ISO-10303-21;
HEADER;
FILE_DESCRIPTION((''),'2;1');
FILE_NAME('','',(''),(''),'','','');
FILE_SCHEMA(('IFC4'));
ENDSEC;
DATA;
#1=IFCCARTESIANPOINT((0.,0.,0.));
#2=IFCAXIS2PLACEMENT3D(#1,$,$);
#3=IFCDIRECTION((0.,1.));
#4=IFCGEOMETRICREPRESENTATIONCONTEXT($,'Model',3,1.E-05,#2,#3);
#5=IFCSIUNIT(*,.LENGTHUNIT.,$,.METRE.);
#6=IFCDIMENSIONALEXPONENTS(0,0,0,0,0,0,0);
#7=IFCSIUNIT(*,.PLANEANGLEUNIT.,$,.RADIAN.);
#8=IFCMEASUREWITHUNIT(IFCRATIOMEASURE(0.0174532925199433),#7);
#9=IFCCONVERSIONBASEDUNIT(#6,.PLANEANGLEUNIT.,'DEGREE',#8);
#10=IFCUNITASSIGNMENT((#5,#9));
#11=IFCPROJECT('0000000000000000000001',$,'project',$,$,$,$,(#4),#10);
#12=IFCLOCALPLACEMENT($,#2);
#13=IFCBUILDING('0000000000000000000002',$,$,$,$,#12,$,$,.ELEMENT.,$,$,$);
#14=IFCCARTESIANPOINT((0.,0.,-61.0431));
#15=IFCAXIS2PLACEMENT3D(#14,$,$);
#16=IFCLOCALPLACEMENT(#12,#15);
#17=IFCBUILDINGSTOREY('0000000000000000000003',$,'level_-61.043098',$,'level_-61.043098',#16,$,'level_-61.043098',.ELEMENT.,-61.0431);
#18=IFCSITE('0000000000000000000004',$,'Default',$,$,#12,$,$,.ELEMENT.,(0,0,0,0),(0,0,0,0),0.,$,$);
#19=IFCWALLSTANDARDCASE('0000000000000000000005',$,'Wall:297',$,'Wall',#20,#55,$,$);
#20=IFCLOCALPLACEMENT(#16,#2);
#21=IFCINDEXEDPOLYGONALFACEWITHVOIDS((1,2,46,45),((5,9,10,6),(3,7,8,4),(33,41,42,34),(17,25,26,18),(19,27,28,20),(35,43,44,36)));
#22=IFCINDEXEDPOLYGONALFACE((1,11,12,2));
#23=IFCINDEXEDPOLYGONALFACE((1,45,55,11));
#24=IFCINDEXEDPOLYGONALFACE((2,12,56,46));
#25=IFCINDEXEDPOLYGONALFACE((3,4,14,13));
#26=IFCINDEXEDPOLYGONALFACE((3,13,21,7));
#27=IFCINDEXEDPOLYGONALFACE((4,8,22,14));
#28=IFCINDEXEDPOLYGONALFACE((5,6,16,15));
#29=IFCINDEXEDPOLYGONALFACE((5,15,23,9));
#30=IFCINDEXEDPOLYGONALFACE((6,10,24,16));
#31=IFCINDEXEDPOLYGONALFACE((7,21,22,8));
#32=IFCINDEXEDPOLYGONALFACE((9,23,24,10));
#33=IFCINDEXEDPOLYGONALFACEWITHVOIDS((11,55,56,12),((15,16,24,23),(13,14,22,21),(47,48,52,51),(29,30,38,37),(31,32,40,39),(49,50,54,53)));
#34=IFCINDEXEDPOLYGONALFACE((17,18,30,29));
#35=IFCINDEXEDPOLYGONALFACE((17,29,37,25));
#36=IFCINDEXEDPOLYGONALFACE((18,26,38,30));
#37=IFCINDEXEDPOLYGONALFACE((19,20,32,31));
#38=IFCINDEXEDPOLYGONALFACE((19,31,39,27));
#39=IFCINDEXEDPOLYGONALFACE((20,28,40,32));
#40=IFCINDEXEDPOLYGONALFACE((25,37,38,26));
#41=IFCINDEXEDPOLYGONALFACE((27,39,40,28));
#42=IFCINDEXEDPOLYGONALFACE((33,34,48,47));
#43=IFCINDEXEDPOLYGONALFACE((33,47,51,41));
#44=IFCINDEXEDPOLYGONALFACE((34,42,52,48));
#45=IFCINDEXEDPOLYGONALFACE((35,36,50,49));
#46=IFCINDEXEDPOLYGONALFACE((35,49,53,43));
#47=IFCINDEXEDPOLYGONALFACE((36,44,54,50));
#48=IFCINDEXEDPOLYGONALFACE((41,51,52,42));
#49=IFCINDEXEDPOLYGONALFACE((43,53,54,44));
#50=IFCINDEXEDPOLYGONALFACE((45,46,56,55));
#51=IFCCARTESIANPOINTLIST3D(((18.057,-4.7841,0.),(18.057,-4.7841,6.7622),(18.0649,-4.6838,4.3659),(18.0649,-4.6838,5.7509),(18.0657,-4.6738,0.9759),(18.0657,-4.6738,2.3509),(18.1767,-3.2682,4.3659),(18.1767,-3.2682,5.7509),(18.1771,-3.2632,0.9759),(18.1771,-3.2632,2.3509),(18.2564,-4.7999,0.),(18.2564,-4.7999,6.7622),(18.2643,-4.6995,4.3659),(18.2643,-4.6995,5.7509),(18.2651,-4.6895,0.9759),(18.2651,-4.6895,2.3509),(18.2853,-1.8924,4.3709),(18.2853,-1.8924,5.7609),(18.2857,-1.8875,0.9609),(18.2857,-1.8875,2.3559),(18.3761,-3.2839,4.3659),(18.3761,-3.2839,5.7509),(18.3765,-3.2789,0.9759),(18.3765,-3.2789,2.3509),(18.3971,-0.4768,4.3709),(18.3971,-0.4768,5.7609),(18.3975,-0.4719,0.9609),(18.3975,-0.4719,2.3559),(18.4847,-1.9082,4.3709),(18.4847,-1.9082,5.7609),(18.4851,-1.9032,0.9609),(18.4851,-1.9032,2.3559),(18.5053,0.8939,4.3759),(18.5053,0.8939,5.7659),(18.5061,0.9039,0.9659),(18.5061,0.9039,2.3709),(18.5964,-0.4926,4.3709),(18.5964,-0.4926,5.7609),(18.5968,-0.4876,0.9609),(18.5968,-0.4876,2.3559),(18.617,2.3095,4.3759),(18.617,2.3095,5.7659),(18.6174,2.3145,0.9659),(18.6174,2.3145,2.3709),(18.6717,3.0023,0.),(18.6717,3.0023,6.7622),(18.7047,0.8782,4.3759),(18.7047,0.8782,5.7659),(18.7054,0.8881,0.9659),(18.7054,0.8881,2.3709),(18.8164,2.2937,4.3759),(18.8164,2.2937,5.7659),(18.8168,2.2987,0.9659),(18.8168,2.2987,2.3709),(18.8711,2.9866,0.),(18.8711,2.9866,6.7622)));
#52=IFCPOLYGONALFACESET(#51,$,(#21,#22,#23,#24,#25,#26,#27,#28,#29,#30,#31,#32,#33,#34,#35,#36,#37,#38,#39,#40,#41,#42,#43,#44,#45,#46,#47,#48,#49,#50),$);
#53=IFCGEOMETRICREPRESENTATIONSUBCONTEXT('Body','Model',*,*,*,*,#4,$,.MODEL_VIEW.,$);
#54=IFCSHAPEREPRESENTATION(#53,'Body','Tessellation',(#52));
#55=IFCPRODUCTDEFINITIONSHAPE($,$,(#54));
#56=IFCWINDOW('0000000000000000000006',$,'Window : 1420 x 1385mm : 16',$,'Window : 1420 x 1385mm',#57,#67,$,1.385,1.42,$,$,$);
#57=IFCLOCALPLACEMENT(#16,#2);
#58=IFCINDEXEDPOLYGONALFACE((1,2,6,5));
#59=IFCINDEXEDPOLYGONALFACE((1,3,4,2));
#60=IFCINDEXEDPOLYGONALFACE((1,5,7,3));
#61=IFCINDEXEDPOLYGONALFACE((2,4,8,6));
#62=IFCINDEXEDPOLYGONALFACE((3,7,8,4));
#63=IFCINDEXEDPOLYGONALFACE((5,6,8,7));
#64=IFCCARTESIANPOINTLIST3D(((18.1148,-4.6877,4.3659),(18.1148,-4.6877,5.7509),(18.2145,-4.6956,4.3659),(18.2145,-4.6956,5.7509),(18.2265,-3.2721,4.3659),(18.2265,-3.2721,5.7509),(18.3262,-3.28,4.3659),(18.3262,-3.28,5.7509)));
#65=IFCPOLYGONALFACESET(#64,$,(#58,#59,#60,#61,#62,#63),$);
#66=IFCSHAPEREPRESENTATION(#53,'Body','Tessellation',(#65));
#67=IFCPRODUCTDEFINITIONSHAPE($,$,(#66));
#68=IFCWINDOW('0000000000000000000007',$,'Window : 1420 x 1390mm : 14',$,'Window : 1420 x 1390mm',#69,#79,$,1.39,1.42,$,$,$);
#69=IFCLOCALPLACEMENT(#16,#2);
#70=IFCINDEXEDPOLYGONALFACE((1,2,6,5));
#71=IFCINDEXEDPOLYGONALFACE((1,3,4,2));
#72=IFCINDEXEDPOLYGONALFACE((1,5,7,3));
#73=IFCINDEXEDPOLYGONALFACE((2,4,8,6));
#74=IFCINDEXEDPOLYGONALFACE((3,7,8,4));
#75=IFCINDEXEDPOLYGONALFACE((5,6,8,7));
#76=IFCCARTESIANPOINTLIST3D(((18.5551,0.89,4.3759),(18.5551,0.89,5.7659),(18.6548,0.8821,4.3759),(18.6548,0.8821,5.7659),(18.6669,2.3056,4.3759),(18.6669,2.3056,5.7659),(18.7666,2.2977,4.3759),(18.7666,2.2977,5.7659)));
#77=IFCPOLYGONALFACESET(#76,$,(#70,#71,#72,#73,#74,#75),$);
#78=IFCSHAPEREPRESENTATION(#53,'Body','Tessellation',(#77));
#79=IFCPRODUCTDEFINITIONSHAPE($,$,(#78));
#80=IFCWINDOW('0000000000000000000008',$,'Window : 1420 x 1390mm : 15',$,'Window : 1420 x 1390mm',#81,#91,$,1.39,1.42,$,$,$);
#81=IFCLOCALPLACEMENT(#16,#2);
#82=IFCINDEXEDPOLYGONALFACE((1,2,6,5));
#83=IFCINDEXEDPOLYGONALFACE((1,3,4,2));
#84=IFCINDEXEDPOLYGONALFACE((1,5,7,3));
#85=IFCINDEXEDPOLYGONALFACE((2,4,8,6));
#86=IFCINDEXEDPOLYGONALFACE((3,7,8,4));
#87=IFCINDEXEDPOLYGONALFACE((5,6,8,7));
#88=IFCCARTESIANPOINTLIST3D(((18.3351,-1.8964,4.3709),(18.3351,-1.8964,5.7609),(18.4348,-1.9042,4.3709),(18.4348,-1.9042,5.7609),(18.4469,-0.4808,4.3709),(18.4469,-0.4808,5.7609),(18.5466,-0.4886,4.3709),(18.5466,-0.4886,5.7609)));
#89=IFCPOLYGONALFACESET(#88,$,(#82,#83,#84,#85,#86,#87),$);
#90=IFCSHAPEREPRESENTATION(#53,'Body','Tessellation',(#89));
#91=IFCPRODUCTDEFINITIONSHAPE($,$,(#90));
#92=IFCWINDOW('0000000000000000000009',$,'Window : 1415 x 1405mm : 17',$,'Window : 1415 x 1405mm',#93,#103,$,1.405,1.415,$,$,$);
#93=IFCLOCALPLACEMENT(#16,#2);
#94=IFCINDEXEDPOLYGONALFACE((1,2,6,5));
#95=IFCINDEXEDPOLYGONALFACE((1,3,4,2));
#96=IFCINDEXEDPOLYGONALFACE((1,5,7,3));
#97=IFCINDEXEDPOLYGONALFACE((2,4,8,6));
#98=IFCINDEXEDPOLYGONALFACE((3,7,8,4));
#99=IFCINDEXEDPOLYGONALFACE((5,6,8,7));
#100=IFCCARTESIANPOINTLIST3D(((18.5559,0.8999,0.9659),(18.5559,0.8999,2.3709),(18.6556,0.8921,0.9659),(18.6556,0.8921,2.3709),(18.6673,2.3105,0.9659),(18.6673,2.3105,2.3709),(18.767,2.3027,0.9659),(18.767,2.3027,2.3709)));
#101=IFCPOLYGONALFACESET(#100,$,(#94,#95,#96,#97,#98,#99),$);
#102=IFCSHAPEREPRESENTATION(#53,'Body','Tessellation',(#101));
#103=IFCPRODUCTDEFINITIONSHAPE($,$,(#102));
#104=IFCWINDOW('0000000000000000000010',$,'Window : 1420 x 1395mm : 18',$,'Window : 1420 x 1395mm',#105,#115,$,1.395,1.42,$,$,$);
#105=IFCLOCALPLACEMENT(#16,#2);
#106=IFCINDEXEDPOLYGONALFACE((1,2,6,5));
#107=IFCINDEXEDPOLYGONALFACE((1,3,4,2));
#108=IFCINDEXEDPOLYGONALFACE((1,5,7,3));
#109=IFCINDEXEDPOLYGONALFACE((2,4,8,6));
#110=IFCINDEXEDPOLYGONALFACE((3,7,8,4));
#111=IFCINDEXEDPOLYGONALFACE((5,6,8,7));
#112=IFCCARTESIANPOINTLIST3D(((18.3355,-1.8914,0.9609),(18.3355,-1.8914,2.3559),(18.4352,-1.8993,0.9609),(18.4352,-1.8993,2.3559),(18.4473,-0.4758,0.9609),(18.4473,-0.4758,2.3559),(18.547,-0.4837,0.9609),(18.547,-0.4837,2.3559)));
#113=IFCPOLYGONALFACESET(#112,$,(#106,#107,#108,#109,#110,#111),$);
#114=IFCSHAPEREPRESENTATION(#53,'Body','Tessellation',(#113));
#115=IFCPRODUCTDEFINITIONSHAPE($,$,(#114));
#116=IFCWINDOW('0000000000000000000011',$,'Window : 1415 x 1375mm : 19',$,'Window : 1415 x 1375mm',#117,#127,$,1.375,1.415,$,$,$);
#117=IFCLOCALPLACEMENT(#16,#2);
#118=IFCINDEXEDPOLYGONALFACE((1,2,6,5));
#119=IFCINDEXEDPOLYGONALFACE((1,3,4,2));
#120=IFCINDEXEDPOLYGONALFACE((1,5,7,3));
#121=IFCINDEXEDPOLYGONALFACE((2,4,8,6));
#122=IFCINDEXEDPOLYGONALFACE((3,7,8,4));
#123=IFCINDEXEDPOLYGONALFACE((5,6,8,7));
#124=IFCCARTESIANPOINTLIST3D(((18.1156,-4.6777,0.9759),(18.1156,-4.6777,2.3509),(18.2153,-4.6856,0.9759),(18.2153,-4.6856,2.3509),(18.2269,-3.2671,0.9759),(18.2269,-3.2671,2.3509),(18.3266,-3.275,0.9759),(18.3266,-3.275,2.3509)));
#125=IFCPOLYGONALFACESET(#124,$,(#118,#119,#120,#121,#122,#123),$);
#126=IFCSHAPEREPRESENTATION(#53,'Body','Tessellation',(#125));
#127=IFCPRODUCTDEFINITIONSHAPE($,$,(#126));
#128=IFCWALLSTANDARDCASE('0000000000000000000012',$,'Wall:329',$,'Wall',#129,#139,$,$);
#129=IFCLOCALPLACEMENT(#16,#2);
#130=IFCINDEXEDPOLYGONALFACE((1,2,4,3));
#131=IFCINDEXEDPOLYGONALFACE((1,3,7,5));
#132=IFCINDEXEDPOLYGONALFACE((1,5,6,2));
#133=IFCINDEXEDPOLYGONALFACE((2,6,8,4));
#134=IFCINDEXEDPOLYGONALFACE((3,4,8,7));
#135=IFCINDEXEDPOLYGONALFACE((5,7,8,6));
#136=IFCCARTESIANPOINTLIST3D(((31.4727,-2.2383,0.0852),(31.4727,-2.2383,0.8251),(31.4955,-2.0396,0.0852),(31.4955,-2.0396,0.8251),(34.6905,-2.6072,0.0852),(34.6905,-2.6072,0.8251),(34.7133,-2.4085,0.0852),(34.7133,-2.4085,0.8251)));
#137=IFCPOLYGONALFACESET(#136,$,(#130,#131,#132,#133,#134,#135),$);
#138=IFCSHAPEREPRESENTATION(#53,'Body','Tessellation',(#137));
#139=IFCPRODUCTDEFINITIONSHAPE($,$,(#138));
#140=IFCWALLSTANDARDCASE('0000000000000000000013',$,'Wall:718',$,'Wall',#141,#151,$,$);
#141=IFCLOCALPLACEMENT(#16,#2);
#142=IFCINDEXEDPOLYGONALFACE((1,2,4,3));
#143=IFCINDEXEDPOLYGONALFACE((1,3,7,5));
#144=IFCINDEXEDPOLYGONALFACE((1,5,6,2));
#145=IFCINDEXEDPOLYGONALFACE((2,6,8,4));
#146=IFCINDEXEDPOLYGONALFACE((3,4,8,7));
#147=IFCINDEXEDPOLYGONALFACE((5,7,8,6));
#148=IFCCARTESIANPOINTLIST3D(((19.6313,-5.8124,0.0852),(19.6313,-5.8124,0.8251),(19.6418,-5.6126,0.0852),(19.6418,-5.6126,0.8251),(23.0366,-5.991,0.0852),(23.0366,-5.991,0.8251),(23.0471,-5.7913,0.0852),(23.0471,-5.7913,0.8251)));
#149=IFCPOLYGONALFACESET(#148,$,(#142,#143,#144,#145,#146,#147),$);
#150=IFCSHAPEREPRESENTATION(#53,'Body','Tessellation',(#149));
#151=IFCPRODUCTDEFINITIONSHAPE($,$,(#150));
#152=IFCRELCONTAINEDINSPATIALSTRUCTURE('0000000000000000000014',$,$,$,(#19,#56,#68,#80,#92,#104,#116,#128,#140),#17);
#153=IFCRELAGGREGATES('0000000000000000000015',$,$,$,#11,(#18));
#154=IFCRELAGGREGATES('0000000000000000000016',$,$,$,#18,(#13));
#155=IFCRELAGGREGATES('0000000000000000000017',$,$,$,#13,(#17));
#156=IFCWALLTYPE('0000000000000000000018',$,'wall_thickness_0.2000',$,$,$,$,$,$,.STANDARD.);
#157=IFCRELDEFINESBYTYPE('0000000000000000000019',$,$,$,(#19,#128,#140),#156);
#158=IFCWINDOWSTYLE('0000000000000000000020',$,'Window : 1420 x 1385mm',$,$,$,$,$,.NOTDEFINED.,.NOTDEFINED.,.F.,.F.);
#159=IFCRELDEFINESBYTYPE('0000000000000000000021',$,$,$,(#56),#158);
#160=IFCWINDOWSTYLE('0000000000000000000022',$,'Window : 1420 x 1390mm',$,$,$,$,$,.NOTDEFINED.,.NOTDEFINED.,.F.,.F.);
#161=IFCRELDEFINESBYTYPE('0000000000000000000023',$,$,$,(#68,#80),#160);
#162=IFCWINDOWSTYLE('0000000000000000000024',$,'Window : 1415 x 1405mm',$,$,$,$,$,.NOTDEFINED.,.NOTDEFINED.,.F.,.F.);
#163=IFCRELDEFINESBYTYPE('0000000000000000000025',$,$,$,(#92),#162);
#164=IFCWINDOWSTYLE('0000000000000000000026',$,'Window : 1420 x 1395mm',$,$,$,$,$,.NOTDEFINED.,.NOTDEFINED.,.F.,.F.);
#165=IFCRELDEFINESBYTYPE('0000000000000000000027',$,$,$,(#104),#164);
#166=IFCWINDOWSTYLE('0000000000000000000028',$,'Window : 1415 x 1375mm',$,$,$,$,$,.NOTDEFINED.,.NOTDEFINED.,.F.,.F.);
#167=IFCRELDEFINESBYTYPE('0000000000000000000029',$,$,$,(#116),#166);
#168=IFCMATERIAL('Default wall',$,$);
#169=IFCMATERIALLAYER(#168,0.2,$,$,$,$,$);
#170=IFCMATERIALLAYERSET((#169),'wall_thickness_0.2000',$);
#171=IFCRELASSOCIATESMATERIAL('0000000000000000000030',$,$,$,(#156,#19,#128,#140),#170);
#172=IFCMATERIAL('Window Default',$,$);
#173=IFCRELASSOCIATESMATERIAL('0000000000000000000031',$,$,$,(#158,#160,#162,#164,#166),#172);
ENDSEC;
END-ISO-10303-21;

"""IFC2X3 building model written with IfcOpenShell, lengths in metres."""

from ifc_helpers import new_model, entity, si_unit, converted_unit, direction, frame, frame_2d, origin, origin_2d_with_axis, place, context, subcontext, project, spatial, polyline, rectangle, outline, extrude, source, transform, mapped, material, layer, layer_set, layer_usage, type_object, type_shapes, element, fill, save


model = new_model("IFC2X3")

# Units and contexts
model_context = context("Model", 3, precision=1e-05, world=origin(), true_north=direction((0.0, 1.0)))
body_context = subcontext(model_context, "Body", "Model", "MODEL_VIEW")
ifc_project = project(units=[si_unit("LENGTHUNIT", "METRE"), converted_unit("PLANEANGLEUNIT", "DEGREE", entity("IfcRatioMeasure", 0.0174532925199433), si_unit("PLANEANGLEUNIT", "RADIAN"), dimensions=[0, 0, 0, 0, 0, 0, 0])], contexts=[model_context])

# Site, building, storey
placement_1 = place(None, origin())
site = spatial("IfcSite", under=ifc_project, at=placement_1, Name="Default", CompositionType="ELEMENT", RefLatitude=(0, 0, 0, 0), RefLongitude=(0, 0, 0, 0), RefElevation=0.0)
building = spatial("IfcBuilding", under=site, at=placement_1, CompositionType="ELEMENT")
storey_placement = place(placement_1, frame((0.0, 0.0, -61.0431)))
storey = spatial("IfcBuildingStorey", under=building, at=storey_placement, Name="level_-61.043098", ObjectType="level_-61.043098", LongName="level_-61.043098", CompositionType="ELEMENT", Elevation=-61.0431)

# Wall, openings, windows
ifc_material_1 = material(Name="Default wall")
ifc_layer = layer(ifc_material_1, 0.2)
ifc_layer_set = layer_set([ifc_layer], Name="wall_thickness_0.2000")
ifc_layer_usage = layer_usage(ifc_layer_set, "AXIS2", "POSITIVE", -0.1)
wall_type = type_object("IfcWallType", Name="wall_thickness_0.2000", PredefinedType="STANDARD", material=ifc_layer_set)
wall_1_placement = place(storey_placement, frame((18.7714, 2.9945, 0.0), z_axis=(0.0, 0.0, 1.0), x_axis=(-0.078701, -0.996898, 0.0)))
wall_1 = element("IfcWallStandardCase", 1, at=wall_1_placement, inside=storey, type_object=wall_type, material=ifc_layer_usage, Name="Wall:297", ObjectType="Wall", context=body_context, shape_type="SweptSolid", body=[
    extrude(outline(polyline([(7.8107, -0.1), (7.8107, 0.1), (0.0, 0.1), (0.0, -0.1), (7.8107, -0.1)])), origin(), (0.0, 0.0, 1.0), 6.7622),
])
opening_1_placement = place(wall_1_placement, frame((0.695, -0.1, 4.3759)))
opening_1 = element("IfcOpeningElement", 2, at=opening_1_placement, cuts=wall_1, ObjectType="Opening", context=body_context, shape_type="SweptSolid", body=[
    extrude(rectangle(XDim=1.42, YDim=1.39, at=frame_2d((0.695, 0.71), x_axis=(0.0, 1.0))), frame((0.0, 0.0, 0.0), z_axis=(0.0, 1.0, 0.0), x_axis=(0.0, 0.0, 1.0)), (0.0, 0.0, 1.0), 0.2),
])
opening_2_placement = place(wall_1_placement, frame((3.49, -0.1, 4.3709)))
opening_2 = element("IfcOpeningElement", 3, at=opening_2_placement, cuts=wall_1, ObjectType="Opening", context=body_context, shape_type="SweptSolid", body=[
    extrude(rectangle(XDim=1.42, YDim=1.39, at=frame_2d((0.695, 0.71), x_axis=(0.0, 1.0))), frame((0.0, 0.0, 0.0), z_axis=(0.0, 1.0, 0.0), x_axis=(0.0, 0.0, 1.0)), (0.0, 0.0, 1.0), 0.2),
])
opening_3_placement = place(wall_1_placement, frame((6.29, -0.1, 4.3659)))
opening_3 = element("IfcOpeningElement", 4, at=opening_3_placement, cuts=wall_1, ObjectType="Opening", context=body_context, shape_type="SweptSolid", body=[
    extrude(rectangle(XDim=1.42, YDim=1.385, at=frame_2d((0.6925, 0.71), x_axis=(0.0, 1.0))), frame((0.0, 0.0, 0.0), z_axis=(0.0, 1.0, 0.0), x_axis=(0.0, 0.0, 1.0)), (0.0, 0.0, 1.0), 0.2),
])
opening_4_placement = place(wall_1_placement, frame((0.69, -0.1, 0.9659)))
opening_4 = element("IfcOpeningElement", 5, at=opening_4_placement, cuts=wall_1, ObjectType="Opening", context=body_context, shape_type="SweptSolid", body=[
    extrude(rectangle(XDim=1.415, YDim=1.405, at=frame_2d((0.7025, 0.7075), x_axis=(0.0, 1.0))), frame((0.0, 0.0, 0.0), z_axis=(0.0, 1.0, 0.0), x_axis=(0.0, 0.0, 1.0)), (0.0, 0.0, 1.0), 0.2),
])
opening_5_placement = place(wall_1_placement, frame((3.485, -0.1, 0.9609)))
opening_5 = element("IfcOpeningElement", 6, at=opening_5_placement, cuts=wall_1, ObjectType="Opening", context=body_context, shape_type="SweptSolid", body=[
    extrude(rectangle(XDim=1.42, YDim=1.395, at=frame_2d((0.6975, 0.71), x_axis=(0.0, 1.0))), frame((0.0, 0.0, 0.0), z_axis=(0.0, 1.0, 0.0), x_axis=(0.0, 0.0, 1.0)), (0.0, 0.0, 1.0), 0.2),
])
opening_6_placement = place(wall_1_placement, frame((6.285, -0.1, 0.9759)))
opening_6 = element("IfcOpeningElement", 7, at=opening_6_placement, cuts=wall_1, ObjectType="Opening", context=body_context, shape_type="SweptSolid", body=[
    extrude(rectangle(XDim=1.415, YDim=1.375, at=frame_2d((0.6875, 0.7075), x_axis=(0.0, 1.0))), frame((0.0, 0.0, 0.0), z_axis=(0.0, 1.0, 0.0), x_axis=(0.0, 0.0, 1.0)), (0.0, 0.0, 1.0), 0.2),
])
ifc_material_2 = material(Name="Window Default")
window_style_1 = type_object("IfcWindowStyle", Name="Window : 1420 x 1385mm", ConstructionType="NOTDEFINED", OperationType="NOTDEFINED", ParameterTakesPrecedence=False, Sizeable=False, material=ifc_material_2)
shared_shape_1 = source(origin(), body_context, "Body", "SweptSolid", [
    extrude(rectangle(XDim=0.1, YDim=1.42, at=origin_2d_with_axis()), frame((0.71, 0.1, 0.0), z_axis=(0.0, 0.0, 1.0), x_axis=(0.0, 1.0, 0.0)), (0.0, 0.0, 1.0), 1.385),
])
type_shapes(window_style_1, [shared_shape_1])
window_1_placement = place(opening_3_placement, origin())
window_1 = element("IfcWindow", 8, at=window_1_placement, inside=storey, type_object=window_style_1, Name="Window : 1420 x 1385mm : 16", ObjectType="Window : 1420 x 1385mm", OverallHeight=1.385, OverallWidth=1.42, context=body_context, shape_type="MappedRepresentation", body=[
    mapped(shared_shape_1, transform((0.0, 0.0, 0.0), scale=1.0)),
])
fill(opening_3, window_1)
window_style_2 = type_object("IfcWindowStyle", Name="Window : 1420 x 1390mm", ConstructionType="NOTDEFINED", OperationType="NOTDEFINED", ParameterTakesPrecedence=False, Sizeable=False, material=ifc_material_2)
shared_shape_2 = source(origin(), body_context, "Body", "SweptSolid", [
    extrude(rectangle(XDim=0.1, YDim=1.42, at=origin_2d_with_axis()), frame((0.71, 0.1, 0.0), z_axis=(0.0, 0.0, 1.0), x_axis=(0.0, 1.0, 0.0)), (0.0, 0.0, 1.0), 1.39),
])
type_shapes(window_style_2, [shared_shape_2])
window_2_placement = place(opening_1_placement, origin())
window_2 = element("IfcWindow", 9, at=window_2_placement, inside=storey, type_object=window_style_2, Name="Window : 1420 x 1390mm : 14", ObjectType="Window : 1420 x 1390mm", OverallHeight=1.39, OverallWidth=1.42, context=body_context, shape_type="MappedRepresentation", body=[
    mapped(shared_shape_2, transform((0.0, 0.0, 0.0), scale=1.0)),
])
fill(opening_1, window_2)
window_3_placement = place(opening_2_placement, origin())
window_3 = element("IfcWindow", 10, at=window_3_placement, inside=storey, type_object=window_style_2, Name="Window : 1420 x 1390mm : 15", ObjectType="Window : 1420 x 1390mm", OverallHeight=1.39, OverallWidth=1.42, context=body_context, shape_type="MappedRepresentation", body=[
    mapped(shared_shape_2, transform((0.0, 0.0, 0.0), scale=1.0)),
])
fill(opening_2, window_3)
window_style_3 = type_object("IfcWindowStyle", Name="Window : 1415 x 1405mm", ConstructionType="NOTDEFINED", OperationType="NOTDEFINED", ParameterTakesPrecedence=False, Sizeable=False, material=ifc_material_2)
shared_shape_3 = source(origin(), body_context, "Body", "SweptSolid", [
    extrude(rectangle(XDim=0.1, YDim=1.415, at=origin_2d_with_axis()), frame((0.7075, 0.1, 0.0), z_axis=(0.0, 0.0, 1.0), x_axis=(0.0, 1.0, 0.0)), (0.0, 0.0, 1.0), 1.405),
])
type_shapes(window_style_3, [shared_shape_3])
window_4_placement = place(opening_4_placement, origin())
window_4 = element("IfcWindow", 11, at=window_4_placement, inside=storey, type_object=window_style_3, Name="Window : 1415 x 1405mm : 17", ObjectType="Window : 1415 x 1405mm", OverallHeight=1.405, OverallWidth=1.415, context=body_context, shape_type="MappedRepresentation", body=[
    mapped(shared_shape_3, transform((0.0, 0.0, 0.0), scale=1.0)),
])
fill(opening_4, window_4)
window_style_4 = type_object("IfcWindowStyle", Name="Window : 1420 x 1395mm", ConstructionType="NOTDEFINED", OperationType="NOTDEFINED", ParameterTakesPrecedence=False, Sizeable=False, material=ifc_material_2)
shared_shape_4 = source(origin(), body_context, "Body", "SweptSolid", [
    extrude(rectangle(XDim=0.1, YDim=1.42, at=origin_2d_with_axis()), frame((0.71, 0.1, 0.0), z_axis=(0.0, 0.0, 1.0), x_axis=(0.0, 1.0, 0.0)), (0.0, 0.0, 1.0), 1.395),
])
type_shapes(window_style_4, [shared_shape_4])
window_5_placement = place(opening_5_placement, origin())
window_5 = element("IfcWindow", 12, at=window_5_placement, inside=storey, type_object=window_style_4, Name="Window : 1420 x 1395mm : 18", ObjectType="Window : 1420 x 1395mm", OverallHeight=1.395, OverallWidth=1.42, context=body_context, shape_type="MappedRepresentation", body=[
    mapped(shared_shape_4, transform((0.0, 0.0, 0.0), scale=1.0)),
])
fill(opening_5, window_5)
window_style_5 = type_object("IfcWindowStyle", Name="Window : 1415 x 1375mm", ConstructionType="NOTDEFINED", OperationType="NOTDEFINED", ParameterTakesPrecedence=False, Sizeable=False, material=ifc_material_2)
shared_shape_5 = source(origin(), body_context, "Body", "SweptSolid", [
    extrude(rectangle(XDim=0.1, YDim=1.415, at=origin_2d_with_axis()), frame((0.7075, 0.1, 0.0), z_axis=(0.0, 0.0, 1.0), x_axis=(0.0, 1.0, 0.0)), (0.0, 0.0, 1.0), 1.375),
])
type_shapes(window_style_5, [shared_shape_5])
window_6_placement = place(opening_6_placement, origin())
window_6 = element("IfcWindow", 13, at=window_6_placement, inside=storey, type_object=window_style_5, Name="Window : 1415 x 1375mm : 19", ObjectType="Window : 1415 x 1375mm", OverallHeight=1.375, OverallWidth=1.415, context=body_context, shape_type="MappedRepresentation", body=[
    mapped(shared_shape_5, transform((0.0, 0.0, 0.0), scale=1.0)),
])
fill(opening_6, window_6)

# Walls
placement_2 = place(placement_1, frame((0.0, 0.0, -60.9579)))
wall_2_placement = place(placement_2, frame((31.4841, -2.139, 0.0), z_axis=(0.0, 0.0, 1.0), x_axis=(0.993495, -0.113878, 0.0)))
element("IfcWallStandardCase", 14, at=wall_2_placement, inside=storey, type_object=wall_type, material=ifc_layer_usage, Name="Wall:329", ObjectType="Wall", context=body_context, shape_type="SweptSolid", body=[
    extrude(outline(polyline([(3.2388, -0.1), (3.2388, 0.1), (0.0, 0.1), (0.0, -0.1), (3.2388, -0.1)])), origin(), (0.0, 0.0, 1.0), 0.7399),
])
placement_3 = place(placement_1, frame((0.0, 0.0, -60.9579)))
wall_3_placement = place(placement_3, frame((19.6365, -5.7125, 0.0), z_axis=(0.0, 0.0, 1.0), x_axis=(0.998627, -0.052388, 0.0)))
element("IfcWallStandardCase", 15, at=wall_3_placement, inside=storey, type_object=wall_type, material=ifc_layer_usage, Name="Wall:718", ObjectType="Wall", context=body_context, shape_type="SweptSolid", body=[
    extrude(outline(polyline([(3.41, -0.1), (3.41, 0.1), (0.0, 0.1), (0.0, -0.1), (3.41, -0.1)])), origin(), (0.0, 0.0, 1.0), 0.7399),
])

save(model, "model.ifc")
